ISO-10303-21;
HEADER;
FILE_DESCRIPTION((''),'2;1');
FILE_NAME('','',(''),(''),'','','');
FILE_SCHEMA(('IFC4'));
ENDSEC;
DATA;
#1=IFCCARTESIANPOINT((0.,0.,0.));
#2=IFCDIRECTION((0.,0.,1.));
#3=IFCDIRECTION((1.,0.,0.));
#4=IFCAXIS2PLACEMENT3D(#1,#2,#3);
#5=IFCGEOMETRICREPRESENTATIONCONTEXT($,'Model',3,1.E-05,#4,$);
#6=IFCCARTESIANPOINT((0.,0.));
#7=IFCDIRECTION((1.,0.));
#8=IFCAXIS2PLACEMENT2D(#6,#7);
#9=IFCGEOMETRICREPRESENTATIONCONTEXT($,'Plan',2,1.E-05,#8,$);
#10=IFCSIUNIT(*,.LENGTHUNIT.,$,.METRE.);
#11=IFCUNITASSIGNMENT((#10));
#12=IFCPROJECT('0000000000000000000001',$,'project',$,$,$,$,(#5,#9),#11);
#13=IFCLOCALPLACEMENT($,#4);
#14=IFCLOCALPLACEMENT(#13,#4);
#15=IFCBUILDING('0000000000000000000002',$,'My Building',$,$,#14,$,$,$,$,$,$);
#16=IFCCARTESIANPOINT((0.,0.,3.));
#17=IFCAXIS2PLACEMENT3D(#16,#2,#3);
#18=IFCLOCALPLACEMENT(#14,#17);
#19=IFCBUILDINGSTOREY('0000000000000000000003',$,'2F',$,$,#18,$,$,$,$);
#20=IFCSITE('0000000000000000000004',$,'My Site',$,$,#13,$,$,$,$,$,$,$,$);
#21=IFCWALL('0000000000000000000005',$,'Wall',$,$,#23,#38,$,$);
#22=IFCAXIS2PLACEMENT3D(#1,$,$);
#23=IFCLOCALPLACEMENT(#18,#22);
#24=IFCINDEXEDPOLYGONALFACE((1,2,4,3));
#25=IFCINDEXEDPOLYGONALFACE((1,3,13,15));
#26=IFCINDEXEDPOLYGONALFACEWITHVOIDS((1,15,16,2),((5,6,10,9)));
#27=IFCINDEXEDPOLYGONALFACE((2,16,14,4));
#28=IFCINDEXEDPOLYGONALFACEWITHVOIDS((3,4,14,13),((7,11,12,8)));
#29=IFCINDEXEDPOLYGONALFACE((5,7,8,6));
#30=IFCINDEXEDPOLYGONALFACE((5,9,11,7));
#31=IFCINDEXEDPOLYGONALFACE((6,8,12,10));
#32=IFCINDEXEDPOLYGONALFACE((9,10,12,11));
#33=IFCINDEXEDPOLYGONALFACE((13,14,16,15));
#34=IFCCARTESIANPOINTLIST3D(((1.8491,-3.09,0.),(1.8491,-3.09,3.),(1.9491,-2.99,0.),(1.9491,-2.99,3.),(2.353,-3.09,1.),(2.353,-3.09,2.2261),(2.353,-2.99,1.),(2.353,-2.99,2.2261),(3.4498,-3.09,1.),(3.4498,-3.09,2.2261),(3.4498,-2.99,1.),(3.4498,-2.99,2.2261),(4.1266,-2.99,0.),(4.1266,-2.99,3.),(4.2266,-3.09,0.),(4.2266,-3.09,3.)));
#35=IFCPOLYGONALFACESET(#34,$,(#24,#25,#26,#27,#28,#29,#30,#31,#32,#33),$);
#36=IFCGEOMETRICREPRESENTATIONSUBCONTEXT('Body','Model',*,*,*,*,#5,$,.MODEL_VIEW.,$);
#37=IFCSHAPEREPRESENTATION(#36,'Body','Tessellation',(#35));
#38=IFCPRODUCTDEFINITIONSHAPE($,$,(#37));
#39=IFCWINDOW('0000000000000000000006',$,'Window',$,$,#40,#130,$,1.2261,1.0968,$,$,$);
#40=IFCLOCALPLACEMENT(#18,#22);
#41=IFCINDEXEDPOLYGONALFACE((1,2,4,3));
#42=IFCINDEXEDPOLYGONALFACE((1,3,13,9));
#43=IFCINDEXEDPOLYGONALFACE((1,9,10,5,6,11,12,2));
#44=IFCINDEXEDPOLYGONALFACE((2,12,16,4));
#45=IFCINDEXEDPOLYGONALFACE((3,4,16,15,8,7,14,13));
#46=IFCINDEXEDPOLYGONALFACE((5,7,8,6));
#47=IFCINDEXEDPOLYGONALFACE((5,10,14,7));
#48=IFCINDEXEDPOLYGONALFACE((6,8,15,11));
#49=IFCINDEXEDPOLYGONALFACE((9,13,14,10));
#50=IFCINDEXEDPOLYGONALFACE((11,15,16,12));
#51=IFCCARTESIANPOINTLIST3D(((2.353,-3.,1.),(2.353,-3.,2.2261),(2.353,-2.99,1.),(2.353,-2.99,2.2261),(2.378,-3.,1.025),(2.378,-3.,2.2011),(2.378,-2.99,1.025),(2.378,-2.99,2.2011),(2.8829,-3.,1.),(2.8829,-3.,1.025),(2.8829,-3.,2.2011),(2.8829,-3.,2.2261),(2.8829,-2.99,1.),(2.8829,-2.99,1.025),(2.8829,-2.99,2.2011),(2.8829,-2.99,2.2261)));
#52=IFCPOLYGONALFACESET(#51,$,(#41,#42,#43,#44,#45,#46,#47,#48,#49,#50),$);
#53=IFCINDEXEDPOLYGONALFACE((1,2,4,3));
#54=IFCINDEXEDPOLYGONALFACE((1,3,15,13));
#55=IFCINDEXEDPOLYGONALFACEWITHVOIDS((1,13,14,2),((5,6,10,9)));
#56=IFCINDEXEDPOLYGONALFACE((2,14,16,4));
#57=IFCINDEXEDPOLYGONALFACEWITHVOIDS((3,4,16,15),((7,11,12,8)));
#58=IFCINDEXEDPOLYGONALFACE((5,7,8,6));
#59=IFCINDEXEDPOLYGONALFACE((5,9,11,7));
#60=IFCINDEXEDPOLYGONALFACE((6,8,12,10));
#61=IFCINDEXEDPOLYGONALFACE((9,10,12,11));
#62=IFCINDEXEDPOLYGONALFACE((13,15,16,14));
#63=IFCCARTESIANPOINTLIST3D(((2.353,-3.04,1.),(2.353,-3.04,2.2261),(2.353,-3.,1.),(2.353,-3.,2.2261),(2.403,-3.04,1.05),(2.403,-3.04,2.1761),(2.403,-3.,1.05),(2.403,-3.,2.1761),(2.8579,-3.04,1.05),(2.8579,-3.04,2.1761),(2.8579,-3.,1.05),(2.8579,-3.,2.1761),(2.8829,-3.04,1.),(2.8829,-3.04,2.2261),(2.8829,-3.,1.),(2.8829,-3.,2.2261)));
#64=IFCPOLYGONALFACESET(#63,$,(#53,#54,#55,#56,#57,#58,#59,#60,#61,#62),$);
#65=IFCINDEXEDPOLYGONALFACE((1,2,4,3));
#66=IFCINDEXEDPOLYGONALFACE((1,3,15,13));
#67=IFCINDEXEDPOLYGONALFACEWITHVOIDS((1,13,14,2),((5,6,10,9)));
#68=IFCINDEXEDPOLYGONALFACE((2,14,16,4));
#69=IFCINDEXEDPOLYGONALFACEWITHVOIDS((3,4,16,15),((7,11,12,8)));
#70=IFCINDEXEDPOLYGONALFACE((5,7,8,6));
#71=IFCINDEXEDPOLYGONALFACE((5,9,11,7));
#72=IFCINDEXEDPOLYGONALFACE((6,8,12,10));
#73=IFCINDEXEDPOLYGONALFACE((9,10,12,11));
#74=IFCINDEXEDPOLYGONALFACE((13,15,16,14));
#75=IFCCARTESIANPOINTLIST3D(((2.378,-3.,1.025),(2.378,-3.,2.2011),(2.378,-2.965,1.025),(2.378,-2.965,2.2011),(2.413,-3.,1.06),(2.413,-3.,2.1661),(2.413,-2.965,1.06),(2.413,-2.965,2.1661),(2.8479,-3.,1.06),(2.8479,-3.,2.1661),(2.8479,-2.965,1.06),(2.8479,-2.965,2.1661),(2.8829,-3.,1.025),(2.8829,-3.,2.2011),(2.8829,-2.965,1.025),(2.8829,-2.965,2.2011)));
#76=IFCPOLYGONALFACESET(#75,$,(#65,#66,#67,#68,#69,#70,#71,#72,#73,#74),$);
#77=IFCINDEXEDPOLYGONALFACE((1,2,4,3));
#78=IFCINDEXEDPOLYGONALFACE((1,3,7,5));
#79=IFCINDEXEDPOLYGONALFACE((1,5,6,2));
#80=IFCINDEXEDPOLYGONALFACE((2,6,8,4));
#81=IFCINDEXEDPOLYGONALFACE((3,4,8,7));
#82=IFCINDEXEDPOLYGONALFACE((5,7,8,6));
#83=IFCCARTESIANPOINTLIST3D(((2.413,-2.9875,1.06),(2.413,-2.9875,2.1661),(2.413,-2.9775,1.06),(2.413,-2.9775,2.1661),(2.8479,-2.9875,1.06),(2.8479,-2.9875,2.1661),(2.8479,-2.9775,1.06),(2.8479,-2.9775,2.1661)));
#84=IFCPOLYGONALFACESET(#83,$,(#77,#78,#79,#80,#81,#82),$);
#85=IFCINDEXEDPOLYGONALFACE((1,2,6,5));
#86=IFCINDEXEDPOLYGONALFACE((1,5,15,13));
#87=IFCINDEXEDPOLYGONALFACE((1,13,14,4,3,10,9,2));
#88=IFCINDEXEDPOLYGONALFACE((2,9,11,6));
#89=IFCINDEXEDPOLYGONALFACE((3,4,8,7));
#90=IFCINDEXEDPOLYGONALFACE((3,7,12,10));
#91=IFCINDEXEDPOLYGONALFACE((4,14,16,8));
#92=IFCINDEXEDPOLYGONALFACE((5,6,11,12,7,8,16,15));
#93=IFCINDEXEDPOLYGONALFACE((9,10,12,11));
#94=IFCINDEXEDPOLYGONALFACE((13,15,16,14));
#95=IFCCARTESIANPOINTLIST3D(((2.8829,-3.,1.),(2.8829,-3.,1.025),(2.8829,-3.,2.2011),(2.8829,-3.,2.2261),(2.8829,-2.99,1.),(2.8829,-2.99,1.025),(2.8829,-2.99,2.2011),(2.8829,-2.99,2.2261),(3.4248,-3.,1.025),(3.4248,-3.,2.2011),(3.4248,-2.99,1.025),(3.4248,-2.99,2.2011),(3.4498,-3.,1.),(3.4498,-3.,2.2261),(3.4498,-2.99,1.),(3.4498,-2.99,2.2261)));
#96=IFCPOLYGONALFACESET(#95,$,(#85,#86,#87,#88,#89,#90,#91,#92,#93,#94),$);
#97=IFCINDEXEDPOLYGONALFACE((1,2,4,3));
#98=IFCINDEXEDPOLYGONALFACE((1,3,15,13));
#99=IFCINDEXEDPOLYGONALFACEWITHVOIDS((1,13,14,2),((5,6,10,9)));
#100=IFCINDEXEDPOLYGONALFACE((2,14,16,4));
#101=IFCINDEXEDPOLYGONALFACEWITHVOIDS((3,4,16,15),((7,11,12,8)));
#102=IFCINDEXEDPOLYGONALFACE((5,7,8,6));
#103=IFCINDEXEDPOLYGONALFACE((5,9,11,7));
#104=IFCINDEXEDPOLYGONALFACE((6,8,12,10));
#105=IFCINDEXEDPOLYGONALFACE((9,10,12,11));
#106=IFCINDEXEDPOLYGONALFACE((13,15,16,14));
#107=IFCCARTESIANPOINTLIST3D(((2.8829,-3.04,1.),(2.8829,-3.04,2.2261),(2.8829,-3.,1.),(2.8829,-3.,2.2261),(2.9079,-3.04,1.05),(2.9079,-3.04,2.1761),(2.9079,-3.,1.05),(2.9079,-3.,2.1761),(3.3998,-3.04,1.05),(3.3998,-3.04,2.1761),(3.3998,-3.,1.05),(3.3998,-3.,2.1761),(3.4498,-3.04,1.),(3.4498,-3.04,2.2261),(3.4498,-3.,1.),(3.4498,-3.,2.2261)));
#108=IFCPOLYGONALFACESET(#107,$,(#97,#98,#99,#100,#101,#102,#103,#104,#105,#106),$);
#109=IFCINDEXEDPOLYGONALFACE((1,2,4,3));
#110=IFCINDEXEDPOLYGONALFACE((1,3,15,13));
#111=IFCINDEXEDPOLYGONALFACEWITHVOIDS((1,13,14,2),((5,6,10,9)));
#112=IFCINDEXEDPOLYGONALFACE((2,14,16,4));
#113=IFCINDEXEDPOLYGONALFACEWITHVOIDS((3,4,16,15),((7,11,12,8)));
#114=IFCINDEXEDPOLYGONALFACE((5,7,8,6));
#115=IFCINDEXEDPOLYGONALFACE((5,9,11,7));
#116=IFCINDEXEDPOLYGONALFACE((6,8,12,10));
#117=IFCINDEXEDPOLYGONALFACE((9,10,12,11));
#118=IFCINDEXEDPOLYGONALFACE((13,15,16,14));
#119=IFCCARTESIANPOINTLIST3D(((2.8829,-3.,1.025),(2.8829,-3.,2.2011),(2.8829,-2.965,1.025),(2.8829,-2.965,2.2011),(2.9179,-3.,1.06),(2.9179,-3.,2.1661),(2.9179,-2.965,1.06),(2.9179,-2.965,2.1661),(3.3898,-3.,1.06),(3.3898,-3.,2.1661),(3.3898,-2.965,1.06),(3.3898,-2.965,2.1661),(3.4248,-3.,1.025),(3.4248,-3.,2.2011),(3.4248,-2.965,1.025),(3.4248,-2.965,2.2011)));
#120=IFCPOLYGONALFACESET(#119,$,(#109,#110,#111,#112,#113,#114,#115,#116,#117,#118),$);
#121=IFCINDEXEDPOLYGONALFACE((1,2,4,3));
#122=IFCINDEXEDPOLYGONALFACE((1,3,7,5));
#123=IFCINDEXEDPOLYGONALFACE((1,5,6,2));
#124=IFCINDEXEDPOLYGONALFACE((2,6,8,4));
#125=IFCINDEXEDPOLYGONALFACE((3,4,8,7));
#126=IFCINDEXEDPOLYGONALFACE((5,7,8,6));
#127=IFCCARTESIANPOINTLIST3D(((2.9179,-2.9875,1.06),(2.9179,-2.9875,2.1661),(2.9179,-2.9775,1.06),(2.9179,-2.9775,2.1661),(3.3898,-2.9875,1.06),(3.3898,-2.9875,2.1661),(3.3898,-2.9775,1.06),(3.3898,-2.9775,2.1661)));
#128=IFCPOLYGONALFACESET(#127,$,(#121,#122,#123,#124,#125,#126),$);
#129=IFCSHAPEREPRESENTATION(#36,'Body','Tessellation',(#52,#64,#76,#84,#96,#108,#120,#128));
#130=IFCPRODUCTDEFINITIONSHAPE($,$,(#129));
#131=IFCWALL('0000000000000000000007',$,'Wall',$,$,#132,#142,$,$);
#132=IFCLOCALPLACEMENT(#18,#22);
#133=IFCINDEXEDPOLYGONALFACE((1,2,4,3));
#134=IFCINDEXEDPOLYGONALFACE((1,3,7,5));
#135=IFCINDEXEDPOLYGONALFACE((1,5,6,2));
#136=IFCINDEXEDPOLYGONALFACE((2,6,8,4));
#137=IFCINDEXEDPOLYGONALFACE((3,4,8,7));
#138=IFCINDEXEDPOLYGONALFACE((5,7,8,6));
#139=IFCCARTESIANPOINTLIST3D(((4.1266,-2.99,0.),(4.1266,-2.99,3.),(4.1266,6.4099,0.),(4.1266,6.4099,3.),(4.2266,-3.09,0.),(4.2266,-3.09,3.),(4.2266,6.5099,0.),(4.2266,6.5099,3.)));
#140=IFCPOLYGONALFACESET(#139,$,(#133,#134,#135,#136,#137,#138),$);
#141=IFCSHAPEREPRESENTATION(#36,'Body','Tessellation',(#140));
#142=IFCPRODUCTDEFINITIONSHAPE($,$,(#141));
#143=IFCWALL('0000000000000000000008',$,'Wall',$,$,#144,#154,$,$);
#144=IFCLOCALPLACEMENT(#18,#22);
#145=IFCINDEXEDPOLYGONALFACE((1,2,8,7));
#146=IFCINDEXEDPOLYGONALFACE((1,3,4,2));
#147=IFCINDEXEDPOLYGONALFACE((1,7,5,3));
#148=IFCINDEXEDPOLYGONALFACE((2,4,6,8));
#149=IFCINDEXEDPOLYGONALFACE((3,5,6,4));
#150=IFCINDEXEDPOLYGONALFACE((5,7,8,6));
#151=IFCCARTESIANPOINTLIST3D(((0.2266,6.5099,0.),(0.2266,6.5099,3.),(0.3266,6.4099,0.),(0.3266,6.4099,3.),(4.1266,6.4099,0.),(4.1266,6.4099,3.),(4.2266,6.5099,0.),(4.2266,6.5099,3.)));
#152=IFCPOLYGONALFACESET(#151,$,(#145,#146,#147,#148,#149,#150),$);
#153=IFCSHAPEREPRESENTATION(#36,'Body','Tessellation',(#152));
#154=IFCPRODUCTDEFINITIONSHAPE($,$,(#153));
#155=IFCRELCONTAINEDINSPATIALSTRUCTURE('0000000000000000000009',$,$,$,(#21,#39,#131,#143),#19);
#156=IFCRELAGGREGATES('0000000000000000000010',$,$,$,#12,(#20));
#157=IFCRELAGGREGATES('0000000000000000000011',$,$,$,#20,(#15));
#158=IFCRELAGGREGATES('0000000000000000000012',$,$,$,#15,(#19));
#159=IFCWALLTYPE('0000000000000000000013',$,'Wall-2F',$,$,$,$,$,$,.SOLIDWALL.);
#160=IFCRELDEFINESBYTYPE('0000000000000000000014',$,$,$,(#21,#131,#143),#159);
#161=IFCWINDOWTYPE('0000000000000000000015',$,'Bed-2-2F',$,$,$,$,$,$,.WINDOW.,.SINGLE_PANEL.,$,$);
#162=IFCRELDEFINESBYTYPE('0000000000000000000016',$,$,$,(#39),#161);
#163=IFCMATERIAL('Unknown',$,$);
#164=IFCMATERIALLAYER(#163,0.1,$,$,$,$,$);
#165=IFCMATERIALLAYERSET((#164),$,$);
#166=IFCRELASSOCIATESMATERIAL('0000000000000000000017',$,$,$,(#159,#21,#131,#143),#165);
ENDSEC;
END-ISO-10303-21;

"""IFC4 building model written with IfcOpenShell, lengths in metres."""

from ifc_helpers import new_model, entity, si_unit, frame, origin_with_axes, origin_2d_with_axis, place, context, subcontext, project, spatial, line, indexed_curve, outline, extrude, shape, source, transform, mapped, material, layer, layer_set, layer_usage, type_object, type_shapes, element, fill, save


model = new_model("IFC4")

# Units and contexts
model_context = context("Model", 3, precision=1e-05, world=origin_with_axes())
plan_context = context("Plan", 2, precision=1e-05, world=origin_2d_with_axis())
body_context_1 = subcontext(model_context, "Body", "Model", "MODEL_VIEW")
body_context_2 = subcontext(plan_context, "Body", "Plan", "PLAN_VIEW")
ifc_project = project(units=[si_unit("LENGTHUNIT", "METRE")], contexts=[model_context, plan_context])

# Site, building, storey
site_placement = place(None, origin_with_axes())
site = spatial("IfcSite", under=ifc_project, at=site_placement, Name="My Site")
building_placement = place(site_placement, origin_with_axes())
building = spatial("IfcBuilding", under=site, at=building_placement, Name="My Building")
storey_placement = place(building_placement, frame((0.0, 0.0, 3.0), z_axis=(0.0, 0.0, 1.0), x_axis=(1.0, 0.0, 0.0)))
storey = spatial("IfcBuildingStorey", under=building, at=storey_placement, Name="2F")

# Shared definitions
ifc_material = material(Name="Unknown")

# Shared definitions
ifc_layer_1 = layer(ifc_material, 0.1)
ifc_layer_set_1 = layer_set([ifc_layer_1])
wall_type = type_object("IfcWallType", Name="Wall-2F", PredefinedType="SOLIDWALL", material=ifc_layer_set_1)

# Wall, opening, window
ifc_layer_usage_1 = layer_usage(ifc_layer_set_1, "AXIS2", "POSITIVE", 0.0)
wall_1_placement = place(storey_placement, frame((1.8491, -3.09, 0.0), z_axis=(0.0, 0.0, 1.0), x_axis=(1.0, 0.0, 0.0)))
wall_1 = element("IfcWall", 1, at=wall_1_placement, inside=storey, type_object=wall_type, material=ifc_layer_usage_1, Name="Wall", context=body_context_1, shape_type="SweptSolid", body=[
    extrude(outline(indexed_curve([(0.0, 0.0), (0.1, 0.1), (2.2775, 0.1), (2.3775, 0.0)], segments=[line(1, 2, 3, 4, 1)])), origin_with_axes(), (0.0, 0.0, 1.0), 3.0),
])
shared_shape_1 = source(origin_with_axes(), body_context_1, "Body", "SweptSolid", [
    extrude(outline(indexed_curve([(0.0, 0.0), (1.0968, 0.0), (1.0968, 1.2261), (0.0, 1.2261)], segments=[line(1, 2, 3, 4, 1)])), frame((0.0, -0.6, 0.0), z_axis=(0.0, -1.0, 0.0), x_axis=(1.0, 0.0, 0.0)), (0.0, 0.0, -1.0), 1.2),
])
opening_1_placement = place(wall_1_placement, frame((0.5039, 0.0, 1.0), z_axis=(0.0, 0.0, 1.0), x_axis=(1.0, 0.0, 0.0)))
opening_1 = element("IfcOpeningElement", 2, at=opening_1_placement, cuts=wall_1, PredefinedType="OPENING", context=body_context_1, shape_type="MappedRepresentation", body=[
    mapped(shared_shape_1, transform((0.0, 0.0, 0.0), x_axis=(1.0, 0.0, 0.0), y_axis=(0.0, 1.0, 0.0), z_axis=(0.0, 0.0, 1.0), scale=1.0)),
])
window_type_1 = type_object("IfcWindowType", Name="Bed-2-2F", PartitioningType="SINGLE_PANEL", PredefinedType="WINDOW")
shared_shape_2 = source(origin_with_axes(), body_context_1, "Body", "SweptSolid", [
    extrude(outline(indexed_curve([(0.5299, 0.0), (0.0, 0.0), (0.0, 1.2261), (0.5299, 1.2261), (0.5299, 1.2011), (0.025, 1.2011), (0.025, 0.025), (0.5299, 0.025)], segments=[line(1, 2, 3, 4, 5, 6, 7, 8, 1)])), frame((0.0, 0.09, 0.0), z_axis=(0.0, -1.0, 0.0), x_axis=(1.0, 0.0, 0.0)), (0.0, 0.0, -1.0), 0.01),
    extrude(outline(indexed_curve([(0.0, 0.0), (0.5299, 0.0), (0.5299, 1.2261), (0.0, 1.2261)], segments=[line(1, 2, 3, 4, 1)]), holes=[indexed_curve([(0.05, 0.05), (0.5049, 0.05), (0.5049, 1.1761), (0.05, 1.1761)], segments=[line(1, 2, 3, 4, 1)])]), frame((0.0, 0.05, 0.0), z_axis=(0.0, -1.0, 0.0), x_axis=(1.0, 0.0, 0.0)), (0.0, 0.0, -1.0), 0.04),
    extrude(outline(indexed_curve([(0.0, 0.0), (0.5049, 0.0), (0.5049, 1.1761), (0.0, 1.1761)], segments=[line(1, 2, 3, 4, 1)]), holes=[indexed_curve([(0.035, 0.035), (0.4699, 0.035), (0.4699, 1.1411), (0.035, 1.1411)], segments=[line(1, 2, 3, 4, 1)])]), frame((0.025, 0.09, 0.025), z_axis=(0.0, -1.0, 0.0), x_axis=(1.0, 0.0, 0.0)), (0.0, 0.0, -1.0), 0.035),
    extrude(outline(indexed_curve([(0.035, 0.035), (0.4699, 0.035), (0.4699, 1.1411), (0.035, 1.1411)], segments=[line(1, 2, 3, 4, 1)])), frame((0.025, 0.1025, 0.025), z_axis=(0.0, -1.0, 0.0), x_axis=(1.0, 0.0, 0.0)), (0.0, 0.0, -1.0), 0.01),
    extrude(outline(indexed_curve([(0.0, 1.2261), (0.5669, 1.2261), (0.5669, 0.0), (0.0, 0.0), (0.0, 0.025), (0.5419, 0.025), (0.5419, 1.2011), (0.0, 1.2011)], segments=[line(1, 2, 3, 4, 5, 6, 7, 8, 1)])), frame((0.5299, 0.09, 0.0), z_axis=(0.0, -1.0, 0.0), x_axis=(1.0, 0.0, 0.0)), (0.0, 0.0, -1.0), 0.01),
    extrude(outline(indexed_curve([(0.0, 0.0), (0.5669, 0.0), (0.5669, 1.2261), (0.0, 1.2261)], segments=[line(1, 2, 3, 4, 1)]), holes=[indexed_curve([(0.025, 0.05), (0.5169, 0.05), (0.5169, 1.1761), (0.025, 1.1761)], segments=[line(1, 2, 3, 4, 1)])]), frame((0.5299, 0.05, 0.0), z_axis=(0.0, -1.0, 0.0), x_axis=(1.0, 0.0, 0.0)), (0.0, 0.0, -1.0), 0.04),
    extrude(outline(indexed_curve([(0.0, 0.0), (0.5419, 0.0), (0.5419, 1.1761), (0.0, 1.1761)], segments=[line(1, 2, 3, 4, 1)]), holes=[indexed_curve([(0.035, 0.035), (0.5069, 0.035), (0.5069, 1.1411), (0.035, 1.1411)], segments=[line(1, 2, 3, 4, 1)])]), frame((0.5299, 0.09, 0.025), z_axis=(0.0, -1.0, 0.0), x_axis=(1.0, 0.0, 0.0)), (0.0, 0.0, -1.0), 0.035),
    extrude(outline(indexed_curve([(0.035, 0.035), (0.5069, 0.035), (0.5069, 1.1411), (0.035, 1.1411)], segments=[line(1, 2, 3, 4, 1)])), frame((0.5299, 0.1025, 0.025), z_axis=(0.0, -1.0, 0.0), x_axis=(1.0, 0.0, 0.0)), (0.0, 0.0, -1.0), 0.01),
])
shared_shape_3 = source(origin_with_axes(), body_context_2, "Body", "Curve2D", [
    entity("IfcIndexedPolyCurve", entity("IfcCartesianPointList2D", [[0.05, 0.05], [0.5049, 0.05]])),
    entity("IfcIndexedPolyCurve", entity("IfcCartesianPointList2D", [[0.0, 0.1], [0.025, 0.1], [0.025, 0.09], [0.05, 0.09], [0.05, 0.05], [0.0, 0.05]]), [entity("IfcLineIndex", [1, 2, 3, 4, 5, 6, 1])]),
    entity("IfcIndexedPolyCurve", entity("IfcCartesianPointList2D", [[0.5299, 0.1], [0.5299, 0.1], [0.5299, 0.09], [0.5049, 0.09], [0.5049, 0.05], [0.5299, 0.05]])),
    entity("IfcIndexedPolyCurve", entity("IfcCartesianPointList2D", [[0.025, 0.09], [0.06, 0.09], [0.06, 0.125], [0.025, 0.125]]), [entity("IfcLineIndex", [1, 2, 3, 4, 1])]),
    entity("IfcIndexedPolyCurve", entity("IfcCartesianPointList2D", [[0.5299, 0.09], [0.4949, 0.09], [0.4949, 0.125], [0.5299, 0.125]]), [entity("IfcLineIndex", [1, 2, 3, 4, 1])]),
    entity("IfcIndexedPolyCurve", entity("IfcCartesianPointList2D", [[0.06, 0.09], [0.4949, 0.09]])),
    entity("IfcIndexedPolyCurve", entity("IfcCartesianPointList2D", [[0.06, 0.125], [0.4949, 0.125]])),
    entity("IfcIndexedPolyCurve", entity("IfcCartesianPointList2D", [[0.06, 0.1075], [0.4949, 0.1075]])),
    entity("IfcIndexedPolyCurve", entity("IfcCartesianPointList2D", [[0.5549, 0.05], [1.0468, 0.05]])),
    entity("IfcIndexedPolyCurve", entity("IfcCartesianPointList2D", [[0.5299, 0.1], [0.5299, 0.1], [0.5299, 0.09], [0.5549, 0.09], [0.5549, 0.05], [0.5299, 0.05]])),
    entity("IfcIndexedPolyCurve", entity("IfcCartesianPointList2D", [[1.0968, 0.1], [1.0718, 0.1], [1.0718, 0.09], [1.0468, 0.09], [1.0468, 0.05], [1.0968, 0.05]]), [entity("IfcLineIndex", [1, 2, 3, 4, 5, 6, 1])]),
    entity("IfcIndexedPolyCurve", entity("IfcCartesianPointList2D", [[0.5299, 0.09], [0.5649, 0.09], [0.5649, 0.125], [0.5299, 0.125]]), [entity("IfcLineIndex", [1, 2, 3, 4, 1])]),
    entity("IfcIndexedPolyCurve", entity("IfcCartesianPointList2D", [[1.0718, 0.09], [1.0368, 0.09], [1.0368, 0.125], [1.0718, 0.125]]), [entity("IfcLineIndex", [1, 2, 3, 4, 1])]),
    entity("IfcIndexedPolyCurve", entity("IfcCartesianPointList2D", [[0.5649, 0.09], [1.0368, 0.09]])),
    entity("IfcIndexedPolyCurve", entity("IfcCartesianPointList2D", [[0.5649, 0.125], [1.0368, 0.125]])),
    entity("IfcIndexedPolyCurve", entity("IfcCartesianPointList2D", [[0.5649, 0.1075], [1.0368, 0.1075]])),
])
type_shapes(window_type_1, [shared_shape_2, shared_shape_3])
window_1_placement = place(opening_1_placement, origin_with_axes())
window_1 = element("IfcWindow", 3, at=window_1_placement, inside=storey, type_object=window_type_1, Name="Window", OverallHeight=1.2261, OverallWidth=1.0968, shapes=[
    shape(body_context_1, "Body", "MappedRepresentation", [mapped(shared_shape_2, transform((0.0, 0.0, 0.0), x_axis=(1.0, 0.0, 0.0), y_axis=(0.0, 1.0, 0.0), z_axis=(0.0, 0.0, 1.0), scale=1.0))]),
    shape(body_context_2, "Body", "MappedRepresentation", [mapped(shared_shape_3, transform((0.0, 0.0, 0.0), x_axis=(1.0, 0.0, 0.0), y_axis=(0.0, 1.0, 0.0), z_axis=(0.0, 0.0, 1.0), scale=1.0))]),
])
fill(opening_1, window_1)

# Walls
ifc_layer_usage_2 = layer_usage(ifc_layer_set_1, "AXIS2", "POSITIVE", 0.0)
wall_2_placement = place(storey_placement, frame((4.2266, -3.09, 0.0), z_axis=(0.0, 0.0, 1.0), x_axis=(0.0, 1.0, 0.0)))
element("IfcWall", 4, at=wall_2_placement, inside=storey, type_object=wall_type, material=ifc_layer_usage_2, Name="Wall", context=body_context_1, shape_type="SweptSolid", body=[
    extrude(outline(indexed_curve([(0.0, 0.0), (0.1, 0.1), (9.4999, 0.1), (9.5999, 0.0)], segments=[line(1, 2, 3, 4, 1)])), origin_with_axes(), (0.0, 0.0, 1.0), 3.0),
])
ifc_layer_usage_3 = layer_usage(ifc_layer_set_1, "AXIS2", "POSITIVE", 0.0)
wall_3_placement = place(storey_placement, frame((4.2266, 6.5099, 0.0), z_axis=(0.0, 0.0, 1.0), x_axis=(-1.0, 0.0, 0.0)))
element("IfcWall", 5, at=wall_3_placement, inside=storey, type_object=wall_type, material=ifc_layer_usage_3, Name="Wall", context=body_context_1, shape_type="SweptSolid", body=[
    extrude(outline(indexed_curve([(0.0, 0.0), (0.1, 0.1), (3.9, 0.1), (4.0, 0.0)], segments=[line(1, 2, 3, 4, 1)])), origin_with_axes(), (0.0, 0.0, 1.0), 3.0),
])

save(model, "model.ifc")
